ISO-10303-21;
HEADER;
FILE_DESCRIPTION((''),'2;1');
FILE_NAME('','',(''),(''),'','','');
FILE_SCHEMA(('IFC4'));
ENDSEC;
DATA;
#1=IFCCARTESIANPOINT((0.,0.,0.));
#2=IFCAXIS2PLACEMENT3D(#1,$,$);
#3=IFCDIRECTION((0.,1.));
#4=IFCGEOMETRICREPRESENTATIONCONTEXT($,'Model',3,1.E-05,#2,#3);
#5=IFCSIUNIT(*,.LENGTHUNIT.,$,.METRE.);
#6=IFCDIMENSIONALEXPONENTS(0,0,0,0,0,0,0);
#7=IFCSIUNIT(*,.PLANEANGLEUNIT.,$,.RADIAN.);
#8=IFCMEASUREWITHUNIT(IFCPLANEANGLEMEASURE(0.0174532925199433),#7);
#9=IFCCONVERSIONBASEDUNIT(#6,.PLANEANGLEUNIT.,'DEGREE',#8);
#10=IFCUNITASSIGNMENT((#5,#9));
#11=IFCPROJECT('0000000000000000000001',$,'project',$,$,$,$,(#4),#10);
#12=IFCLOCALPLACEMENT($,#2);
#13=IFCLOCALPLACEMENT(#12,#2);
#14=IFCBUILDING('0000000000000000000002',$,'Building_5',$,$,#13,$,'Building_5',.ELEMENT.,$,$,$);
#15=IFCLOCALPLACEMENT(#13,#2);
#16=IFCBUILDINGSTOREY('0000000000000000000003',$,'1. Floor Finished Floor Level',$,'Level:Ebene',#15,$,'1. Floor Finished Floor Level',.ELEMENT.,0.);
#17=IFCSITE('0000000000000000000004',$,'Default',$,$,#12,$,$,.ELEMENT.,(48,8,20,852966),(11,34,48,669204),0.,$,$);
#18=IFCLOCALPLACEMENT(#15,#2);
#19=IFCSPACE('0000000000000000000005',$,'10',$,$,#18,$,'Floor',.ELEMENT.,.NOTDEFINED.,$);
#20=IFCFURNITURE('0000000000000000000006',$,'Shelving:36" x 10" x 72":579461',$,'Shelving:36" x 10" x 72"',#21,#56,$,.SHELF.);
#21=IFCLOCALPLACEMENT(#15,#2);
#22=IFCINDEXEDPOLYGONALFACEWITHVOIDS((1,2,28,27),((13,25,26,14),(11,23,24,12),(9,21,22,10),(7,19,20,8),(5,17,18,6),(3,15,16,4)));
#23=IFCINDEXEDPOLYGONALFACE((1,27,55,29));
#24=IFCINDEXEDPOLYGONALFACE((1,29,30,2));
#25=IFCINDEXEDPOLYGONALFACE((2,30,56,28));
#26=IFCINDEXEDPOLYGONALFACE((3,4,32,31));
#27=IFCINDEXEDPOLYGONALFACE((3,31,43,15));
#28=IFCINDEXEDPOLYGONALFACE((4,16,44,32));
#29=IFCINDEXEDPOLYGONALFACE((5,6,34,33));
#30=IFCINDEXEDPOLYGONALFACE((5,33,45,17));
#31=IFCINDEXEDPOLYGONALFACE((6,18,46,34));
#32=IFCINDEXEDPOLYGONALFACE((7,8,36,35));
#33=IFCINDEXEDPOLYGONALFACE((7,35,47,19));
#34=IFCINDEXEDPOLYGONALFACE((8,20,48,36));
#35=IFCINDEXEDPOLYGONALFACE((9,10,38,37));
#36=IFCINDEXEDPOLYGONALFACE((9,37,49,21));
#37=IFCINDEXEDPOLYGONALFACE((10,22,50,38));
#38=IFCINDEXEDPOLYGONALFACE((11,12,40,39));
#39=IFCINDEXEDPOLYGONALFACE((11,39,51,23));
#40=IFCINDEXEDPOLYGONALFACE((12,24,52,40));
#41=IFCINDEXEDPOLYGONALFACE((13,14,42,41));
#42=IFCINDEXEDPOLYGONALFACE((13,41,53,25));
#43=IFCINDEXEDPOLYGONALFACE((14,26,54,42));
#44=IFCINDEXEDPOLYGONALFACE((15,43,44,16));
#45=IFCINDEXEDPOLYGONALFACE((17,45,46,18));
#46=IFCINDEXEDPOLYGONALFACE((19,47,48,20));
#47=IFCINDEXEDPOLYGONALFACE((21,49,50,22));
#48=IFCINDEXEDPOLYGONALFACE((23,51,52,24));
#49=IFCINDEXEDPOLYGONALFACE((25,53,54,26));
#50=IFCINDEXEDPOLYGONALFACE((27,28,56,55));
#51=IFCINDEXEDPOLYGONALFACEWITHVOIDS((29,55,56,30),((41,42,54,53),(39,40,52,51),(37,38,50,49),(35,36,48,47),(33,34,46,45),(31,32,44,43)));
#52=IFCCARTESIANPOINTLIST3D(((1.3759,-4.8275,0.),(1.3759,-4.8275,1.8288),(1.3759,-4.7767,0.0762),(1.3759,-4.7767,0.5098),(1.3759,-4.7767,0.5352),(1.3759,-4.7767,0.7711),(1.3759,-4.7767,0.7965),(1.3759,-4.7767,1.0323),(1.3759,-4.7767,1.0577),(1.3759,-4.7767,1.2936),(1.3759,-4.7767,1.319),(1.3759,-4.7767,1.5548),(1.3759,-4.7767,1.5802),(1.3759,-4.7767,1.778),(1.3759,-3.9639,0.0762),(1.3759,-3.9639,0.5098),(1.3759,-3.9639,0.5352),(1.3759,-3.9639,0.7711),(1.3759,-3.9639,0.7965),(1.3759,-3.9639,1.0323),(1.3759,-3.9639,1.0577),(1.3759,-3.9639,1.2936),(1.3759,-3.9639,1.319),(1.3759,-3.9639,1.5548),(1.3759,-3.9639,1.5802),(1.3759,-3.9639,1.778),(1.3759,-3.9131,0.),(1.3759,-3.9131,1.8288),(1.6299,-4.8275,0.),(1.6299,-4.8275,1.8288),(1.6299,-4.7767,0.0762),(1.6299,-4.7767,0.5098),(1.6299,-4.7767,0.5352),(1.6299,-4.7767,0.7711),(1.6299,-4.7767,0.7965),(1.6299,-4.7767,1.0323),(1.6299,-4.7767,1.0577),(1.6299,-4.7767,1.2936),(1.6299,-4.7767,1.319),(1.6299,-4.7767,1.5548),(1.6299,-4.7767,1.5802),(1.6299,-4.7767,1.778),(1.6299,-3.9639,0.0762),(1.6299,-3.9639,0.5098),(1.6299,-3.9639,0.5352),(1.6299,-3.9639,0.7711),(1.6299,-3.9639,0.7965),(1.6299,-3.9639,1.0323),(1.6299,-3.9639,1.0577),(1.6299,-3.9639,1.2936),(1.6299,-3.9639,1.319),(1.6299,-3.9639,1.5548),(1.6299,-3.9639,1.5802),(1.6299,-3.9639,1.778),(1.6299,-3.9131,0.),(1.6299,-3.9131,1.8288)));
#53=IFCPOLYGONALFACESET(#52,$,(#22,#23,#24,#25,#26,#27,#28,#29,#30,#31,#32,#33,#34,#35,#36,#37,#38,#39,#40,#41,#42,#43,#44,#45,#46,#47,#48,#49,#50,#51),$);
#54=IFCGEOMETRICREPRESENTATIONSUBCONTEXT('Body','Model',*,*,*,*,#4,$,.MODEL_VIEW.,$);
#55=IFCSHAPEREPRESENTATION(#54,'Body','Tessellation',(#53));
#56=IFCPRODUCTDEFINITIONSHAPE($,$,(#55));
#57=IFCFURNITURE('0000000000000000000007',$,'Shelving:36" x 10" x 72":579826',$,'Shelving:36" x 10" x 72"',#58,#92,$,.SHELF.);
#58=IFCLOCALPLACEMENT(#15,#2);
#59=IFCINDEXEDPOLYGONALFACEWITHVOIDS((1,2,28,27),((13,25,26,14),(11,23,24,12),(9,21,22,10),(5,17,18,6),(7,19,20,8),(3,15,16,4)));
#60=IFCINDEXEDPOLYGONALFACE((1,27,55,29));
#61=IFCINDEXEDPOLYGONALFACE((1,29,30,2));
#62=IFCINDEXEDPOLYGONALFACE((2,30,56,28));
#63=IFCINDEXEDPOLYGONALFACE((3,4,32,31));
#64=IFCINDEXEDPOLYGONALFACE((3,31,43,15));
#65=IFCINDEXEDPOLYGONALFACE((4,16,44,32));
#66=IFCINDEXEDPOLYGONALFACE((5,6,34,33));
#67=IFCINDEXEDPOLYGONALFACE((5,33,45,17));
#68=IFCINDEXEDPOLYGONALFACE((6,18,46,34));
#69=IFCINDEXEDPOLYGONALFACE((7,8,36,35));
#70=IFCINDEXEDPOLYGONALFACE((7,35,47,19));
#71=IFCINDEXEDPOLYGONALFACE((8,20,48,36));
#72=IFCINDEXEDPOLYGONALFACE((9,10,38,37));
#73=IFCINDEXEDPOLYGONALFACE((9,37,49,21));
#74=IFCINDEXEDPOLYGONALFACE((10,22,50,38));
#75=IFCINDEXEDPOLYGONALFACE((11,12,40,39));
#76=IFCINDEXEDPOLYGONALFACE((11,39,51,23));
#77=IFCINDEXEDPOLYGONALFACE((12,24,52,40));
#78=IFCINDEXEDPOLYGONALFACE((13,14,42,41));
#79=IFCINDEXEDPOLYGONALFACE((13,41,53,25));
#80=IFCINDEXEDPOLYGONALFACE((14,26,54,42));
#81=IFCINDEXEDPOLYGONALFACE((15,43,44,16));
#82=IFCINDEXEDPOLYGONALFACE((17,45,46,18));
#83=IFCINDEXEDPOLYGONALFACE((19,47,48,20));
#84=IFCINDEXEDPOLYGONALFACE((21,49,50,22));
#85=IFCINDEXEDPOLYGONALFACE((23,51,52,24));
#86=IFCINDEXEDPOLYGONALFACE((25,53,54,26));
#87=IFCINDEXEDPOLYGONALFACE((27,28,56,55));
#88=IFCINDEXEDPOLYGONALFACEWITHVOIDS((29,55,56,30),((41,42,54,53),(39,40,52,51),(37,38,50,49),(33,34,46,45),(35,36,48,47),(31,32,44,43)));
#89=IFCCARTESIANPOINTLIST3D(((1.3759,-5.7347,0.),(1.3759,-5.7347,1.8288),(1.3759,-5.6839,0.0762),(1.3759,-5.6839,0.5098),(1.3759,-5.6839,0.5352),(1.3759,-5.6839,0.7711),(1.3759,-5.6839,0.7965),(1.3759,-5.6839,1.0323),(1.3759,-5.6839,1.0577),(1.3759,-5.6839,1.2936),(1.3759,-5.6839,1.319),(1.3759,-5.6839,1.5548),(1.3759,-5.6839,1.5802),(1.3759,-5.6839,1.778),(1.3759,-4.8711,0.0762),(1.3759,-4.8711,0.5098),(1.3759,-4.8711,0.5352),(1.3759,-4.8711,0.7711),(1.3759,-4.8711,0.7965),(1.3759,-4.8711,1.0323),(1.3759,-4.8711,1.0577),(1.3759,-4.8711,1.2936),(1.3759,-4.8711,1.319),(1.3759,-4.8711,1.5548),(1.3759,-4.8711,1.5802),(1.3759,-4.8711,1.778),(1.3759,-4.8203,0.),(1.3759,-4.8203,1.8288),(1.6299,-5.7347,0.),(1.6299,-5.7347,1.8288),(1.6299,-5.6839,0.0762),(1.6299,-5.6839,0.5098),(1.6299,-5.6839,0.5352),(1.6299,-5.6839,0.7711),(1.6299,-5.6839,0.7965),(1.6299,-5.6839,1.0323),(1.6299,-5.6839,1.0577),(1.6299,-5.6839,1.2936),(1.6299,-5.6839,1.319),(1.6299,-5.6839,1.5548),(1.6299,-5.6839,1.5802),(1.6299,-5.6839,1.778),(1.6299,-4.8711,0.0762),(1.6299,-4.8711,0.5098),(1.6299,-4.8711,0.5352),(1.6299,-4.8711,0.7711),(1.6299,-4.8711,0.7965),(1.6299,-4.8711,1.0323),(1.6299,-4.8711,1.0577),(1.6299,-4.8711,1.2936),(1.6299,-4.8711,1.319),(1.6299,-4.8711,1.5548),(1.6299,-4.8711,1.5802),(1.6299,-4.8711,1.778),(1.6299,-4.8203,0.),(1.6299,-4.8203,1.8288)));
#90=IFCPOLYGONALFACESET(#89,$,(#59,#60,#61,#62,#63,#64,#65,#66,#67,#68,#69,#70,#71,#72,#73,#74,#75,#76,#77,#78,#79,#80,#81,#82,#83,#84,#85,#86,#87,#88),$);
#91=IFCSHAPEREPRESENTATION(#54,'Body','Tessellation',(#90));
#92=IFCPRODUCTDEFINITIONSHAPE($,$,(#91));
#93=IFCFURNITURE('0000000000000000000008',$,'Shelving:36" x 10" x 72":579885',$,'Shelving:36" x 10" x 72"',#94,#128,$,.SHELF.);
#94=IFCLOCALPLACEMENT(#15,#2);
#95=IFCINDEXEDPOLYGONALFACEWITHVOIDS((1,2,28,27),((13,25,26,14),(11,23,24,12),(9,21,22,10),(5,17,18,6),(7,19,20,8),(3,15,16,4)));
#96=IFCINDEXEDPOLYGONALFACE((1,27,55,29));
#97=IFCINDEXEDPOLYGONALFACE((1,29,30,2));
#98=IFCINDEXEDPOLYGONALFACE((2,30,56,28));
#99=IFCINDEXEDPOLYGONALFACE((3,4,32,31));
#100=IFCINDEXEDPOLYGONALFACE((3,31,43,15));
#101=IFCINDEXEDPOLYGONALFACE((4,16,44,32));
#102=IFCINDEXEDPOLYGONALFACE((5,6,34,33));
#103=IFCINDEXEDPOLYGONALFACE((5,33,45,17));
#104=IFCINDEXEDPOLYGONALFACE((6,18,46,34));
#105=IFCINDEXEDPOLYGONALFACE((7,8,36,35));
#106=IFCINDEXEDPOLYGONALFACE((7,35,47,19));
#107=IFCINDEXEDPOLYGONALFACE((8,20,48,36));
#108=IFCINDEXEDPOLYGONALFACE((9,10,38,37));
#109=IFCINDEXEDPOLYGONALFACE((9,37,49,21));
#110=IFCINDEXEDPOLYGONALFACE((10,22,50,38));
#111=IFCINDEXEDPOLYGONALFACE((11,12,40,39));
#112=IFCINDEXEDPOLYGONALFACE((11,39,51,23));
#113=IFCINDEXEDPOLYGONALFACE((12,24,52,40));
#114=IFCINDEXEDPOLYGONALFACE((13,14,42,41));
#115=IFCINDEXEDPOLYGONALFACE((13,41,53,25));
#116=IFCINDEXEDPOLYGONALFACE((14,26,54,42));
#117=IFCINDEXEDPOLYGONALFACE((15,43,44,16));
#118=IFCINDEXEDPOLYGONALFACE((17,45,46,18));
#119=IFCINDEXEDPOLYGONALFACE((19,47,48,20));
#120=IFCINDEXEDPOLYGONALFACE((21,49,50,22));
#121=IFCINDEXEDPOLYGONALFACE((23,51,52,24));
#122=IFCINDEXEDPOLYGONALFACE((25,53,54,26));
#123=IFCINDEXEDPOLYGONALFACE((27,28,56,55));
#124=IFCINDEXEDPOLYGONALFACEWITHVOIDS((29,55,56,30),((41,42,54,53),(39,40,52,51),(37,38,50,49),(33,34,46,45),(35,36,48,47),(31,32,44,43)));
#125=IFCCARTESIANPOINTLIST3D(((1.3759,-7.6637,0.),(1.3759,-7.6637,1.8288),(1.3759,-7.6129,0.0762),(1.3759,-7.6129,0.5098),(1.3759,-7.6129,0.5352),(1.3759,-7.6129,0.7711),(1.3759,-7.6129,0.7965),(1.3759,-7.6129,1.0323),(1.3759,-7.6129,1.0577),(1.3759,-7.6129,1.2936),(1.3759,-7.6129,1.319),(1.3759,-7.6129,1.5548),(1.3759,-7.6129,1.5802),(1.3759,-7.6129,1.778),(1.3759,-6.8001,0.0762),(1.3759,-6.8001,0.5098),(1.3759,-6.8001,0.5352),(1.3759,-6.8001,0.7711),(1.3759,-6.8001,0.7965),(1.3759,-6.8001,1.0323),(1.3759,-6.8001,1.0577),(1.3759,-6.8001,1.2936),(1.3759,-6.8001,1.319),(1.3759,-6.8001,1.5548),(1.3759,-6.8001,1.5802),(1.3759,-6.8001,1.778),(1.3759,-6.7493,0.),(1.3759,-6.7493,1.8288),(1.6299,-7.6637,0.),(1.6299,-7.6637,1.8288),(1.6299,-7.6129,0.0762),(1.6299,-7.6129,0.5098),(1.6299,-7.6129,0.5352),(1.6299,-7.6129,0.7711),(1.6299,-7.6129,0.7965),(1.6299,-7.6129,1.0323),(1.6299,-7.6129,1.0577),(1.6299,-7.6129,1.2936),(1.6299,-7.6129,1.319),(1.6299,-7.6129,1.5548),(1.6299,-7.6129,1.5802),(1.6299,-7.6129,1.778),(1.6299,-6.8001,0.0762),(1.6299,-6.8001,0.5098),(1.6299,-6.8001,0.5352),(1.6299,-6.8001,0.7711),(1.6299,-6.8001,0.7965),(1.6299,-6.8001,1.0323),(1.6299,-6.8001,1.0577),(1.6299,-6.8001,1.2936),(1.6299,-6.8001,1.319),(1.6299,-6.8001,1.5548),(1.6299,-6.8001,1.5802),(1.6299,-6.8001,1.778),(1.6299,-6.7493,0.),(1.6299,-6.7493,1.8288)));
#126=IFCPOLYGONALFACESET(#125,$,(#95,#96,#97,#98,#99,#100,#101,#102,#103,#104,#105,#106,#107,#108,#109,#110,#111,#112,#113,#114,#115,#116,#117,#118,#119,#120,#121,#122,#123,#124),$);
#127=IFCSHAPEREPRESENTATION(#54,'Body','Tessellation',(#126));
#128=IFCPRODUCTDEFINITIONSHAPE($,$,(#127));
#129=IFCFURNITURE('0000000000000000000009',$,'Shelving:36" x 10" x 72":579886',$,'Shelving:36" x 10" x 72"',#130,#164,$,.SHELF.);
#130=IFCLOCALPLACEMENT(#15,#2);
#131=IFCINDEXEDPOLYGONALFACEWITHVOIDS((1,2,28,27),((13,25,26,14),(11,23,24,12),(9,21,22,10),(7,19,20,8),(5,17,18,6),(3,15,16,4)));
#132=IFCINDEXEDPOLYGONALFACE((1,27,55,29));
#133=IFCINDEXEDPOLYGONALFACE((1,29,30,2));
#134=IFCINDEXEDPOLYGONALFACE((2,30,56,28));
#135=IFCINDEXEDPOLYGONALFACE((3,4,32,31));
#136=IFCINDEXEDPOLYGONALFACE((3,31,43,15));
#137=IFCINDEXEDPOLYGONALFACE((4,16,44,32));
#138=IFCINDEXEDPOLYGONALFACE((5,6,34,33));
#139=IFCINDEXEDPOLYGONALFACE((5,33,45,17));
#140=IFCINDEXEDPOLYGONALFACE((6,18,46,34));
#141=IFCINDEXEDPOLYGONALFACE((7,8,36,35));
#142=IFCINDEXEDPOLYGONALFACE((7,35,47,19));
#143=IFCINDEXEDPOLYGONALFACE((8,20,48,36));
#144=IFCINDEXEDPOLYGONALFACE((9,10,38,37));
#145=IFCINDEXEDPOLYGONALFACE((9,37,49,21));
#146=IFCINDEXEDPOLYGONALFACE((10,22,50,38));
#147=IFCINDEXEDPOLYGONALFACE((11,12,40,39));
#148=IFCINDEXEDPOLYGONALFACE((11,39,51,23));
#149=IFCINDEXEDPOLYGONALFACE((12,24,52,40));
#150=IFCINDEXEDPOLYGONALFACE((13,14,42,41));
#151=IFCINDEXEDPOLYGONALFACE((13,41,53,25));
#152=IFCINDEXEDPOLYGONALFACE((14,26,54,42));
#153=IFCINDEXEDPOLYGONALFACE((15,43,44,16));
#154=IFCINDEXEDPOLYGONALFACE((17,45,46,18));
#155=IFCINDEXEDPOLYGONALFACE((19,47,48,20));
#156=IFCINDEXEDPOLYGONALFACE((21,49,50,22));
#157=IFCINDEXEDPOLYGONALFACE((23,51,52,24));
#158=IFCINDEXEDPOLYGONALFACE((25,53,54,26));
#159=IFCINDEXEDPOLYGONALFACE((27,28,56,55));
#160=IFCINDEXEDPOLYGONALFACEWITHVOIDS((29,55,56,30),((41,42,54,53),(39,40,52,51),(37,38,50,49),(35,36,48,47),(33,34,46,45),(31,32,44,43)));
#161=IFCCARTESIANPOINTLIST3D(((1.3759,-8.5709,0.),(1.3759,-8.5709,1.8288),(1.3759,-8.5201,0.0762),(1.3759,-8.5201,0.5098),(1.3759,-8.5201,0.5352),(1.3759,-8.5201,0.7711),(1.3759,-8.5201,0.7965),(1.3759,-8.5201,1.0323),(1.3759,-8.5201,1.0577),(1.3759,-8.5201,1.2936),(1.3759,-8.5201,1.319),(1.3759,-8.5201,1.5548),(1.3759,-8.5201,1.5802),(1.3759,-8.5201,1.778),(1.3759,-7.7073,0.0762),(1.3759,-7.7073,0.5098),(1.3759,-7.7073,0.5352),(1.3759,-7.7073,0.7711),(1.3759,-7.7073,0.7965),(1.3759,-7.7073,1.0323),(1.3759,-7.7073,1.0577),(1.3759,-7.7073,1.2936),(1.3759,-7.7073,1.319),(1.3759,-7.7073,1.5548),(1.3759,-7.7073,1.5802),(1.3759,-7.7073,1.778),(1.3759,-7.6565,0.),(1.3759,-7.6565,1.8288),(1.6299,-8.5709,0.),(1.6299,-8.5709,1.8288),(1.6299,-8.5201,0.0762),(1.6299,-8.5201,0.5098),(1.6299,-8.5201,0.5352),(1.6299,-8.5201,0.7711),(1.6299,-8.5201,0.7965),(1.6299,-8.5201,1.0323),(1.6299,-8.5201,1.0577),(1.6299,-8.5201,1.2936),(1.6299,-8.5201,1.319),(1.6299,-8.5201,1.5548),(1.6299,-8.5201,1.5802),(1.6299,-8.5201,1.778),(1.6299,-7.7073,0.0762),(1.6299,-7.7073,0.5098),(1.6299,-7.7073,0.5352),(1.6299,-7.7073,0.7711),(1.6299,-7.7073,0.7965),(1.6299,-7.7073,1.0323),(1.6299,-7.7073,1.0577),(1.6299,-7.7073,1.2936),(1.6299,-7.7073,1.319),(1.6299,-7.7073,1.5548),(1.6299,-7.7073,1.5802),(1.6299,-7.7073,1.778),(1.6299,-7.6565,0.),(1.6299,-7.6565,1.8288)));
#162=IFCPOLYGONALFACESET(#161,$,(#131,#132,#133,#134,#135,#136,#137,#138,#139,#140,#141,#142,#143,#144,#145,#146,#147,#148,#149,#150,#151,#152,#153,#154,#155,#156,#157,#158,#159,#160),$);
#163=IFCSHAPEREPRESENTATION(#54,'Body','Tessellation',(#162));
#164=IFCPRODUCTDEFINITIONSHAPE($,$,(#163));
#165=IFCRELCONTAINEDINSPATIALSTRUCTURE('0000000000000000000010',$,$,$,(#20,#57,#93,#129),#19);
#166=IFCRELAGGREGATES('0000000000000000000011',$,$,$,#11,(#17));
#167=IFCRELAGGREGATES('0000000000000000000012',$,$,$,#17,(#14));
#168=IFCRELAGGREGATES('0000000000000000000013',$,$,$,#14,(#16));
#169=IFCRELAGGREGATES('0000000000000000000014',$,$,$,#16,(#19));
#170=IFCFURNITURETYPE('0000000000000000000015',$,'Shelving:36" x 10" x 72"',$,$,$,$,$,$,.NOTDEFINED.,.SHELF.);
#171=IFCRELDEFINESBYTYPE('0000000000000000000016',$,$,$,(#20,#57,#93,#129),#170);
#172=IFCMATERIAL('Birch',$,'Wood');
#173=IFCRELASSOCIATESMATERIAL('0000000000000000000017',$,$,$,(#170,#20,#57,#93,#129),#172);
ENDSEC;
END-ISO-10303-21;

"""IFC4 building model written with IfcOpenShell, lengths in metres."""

from ifc_helpers import new_model, entity, si_unit, converted_unit, direction, frame, origin, place, context, subcontext, project, spatial, indexed_curve, outline, extrude, source, transform, mapped, material, type_object, type_shapes, element, save


model = new_model("IFC4")

# Units and contexts
model_context = context("Model", 3, precision=1e-05, world=origin(), true_north=direction((0.0, 1.0)))
body_context = subcontext(model_context, "Body", "Model", "MODEL_VIEW")
ifc_project = project(units=[si_unit("LENGTHUNIT", "METRE"), converted_unit("PLANEANGLEUNIT", "DEGREE", entity("IfcPlaneAngleMeasure", 0.0174532925199433), si_unit("PLANEANGLEUNIT", "RADIAN"), dimensions=[0, 0, 0, 0, 0, 0, 0])], contexts=[model_context])

# Site, building, storey
site_placement = place(None, origin())
site = spatial("IfcSite", under=ifc_project, at=site_placement, Name="Default", CompositionType="ELEMENT", RefLatitude=(48, 8, 20, 852966), RefLongitude=(11, 34, 48, 669204), RefElevation=0.0)
building_placement = place(site_placement, origin())
building = spatial("IfcBuilding", under=site, at=building_placement, Name="Building_5", LongName="Building_5", CompositionType="ELEMENT")
storey_placement = place(building_placement, origin())
storey = spatial("IfcBuildingStorey", under=building, at=storey_placement, Name="1. Floor Finished Floor Level", ObjectType="Level:Ebene", LongName="1. Floor Finished Floor Level", CompositionType="ELEMENT", Elevation=0.0)

# Shared definitions
space_placement = place(storey_placement, origin())
space = spatial("IfcSpace", under=storey, at=space_placement, Name="10", LongName="Floor", CompositionType="ELEMENT", PredefinedType="NOTDEFINED")

# Furniture
ifc_material_1 = material(Name="Birch", Category="Wood")
furniture_type = type_object("IfcFurnitureType", Name="Shelving:36\" x 10\" x 72\"", AssemblyPlace="NOTDEFINED", PredefinedType="SHELF", material=ifc_material_1)
shared_shape_1 = source(origin(), body_context, "Body", "SweptSolid", [
    extrude(outline(indexed_curve([(-0.4572, -0.9144), (0.4572, -0.9144), (0.4572, 0.9144), (-0.4572, 0.9144), (-0.4572, -0.9144)], self_intersect=False), holes=[indexed_curve([(-0.4064, 0.8636), (0.4064, 0.8636), (0.4064, 0.6658), (-0.4064, 0.6658), (-0.4064, 0.8636)], self_intersect=False), indexed_curve([(-0.4064, -0.8382), (-0.4064, -0.4046), (0.4064, -0.4046), (0.4064, -0.8382), (-0.4064, -0.8382)], self_intersect=False), indexed_curve([(0.4064, 0.1433), (-0.4064, 0.1433), (-0.4064, 0.3792), (0.4064, 0.3792), (0.4064, 0.1433)], self_intersect=False), indexed_curve([(-0.4064, 0.6404), (0.4064, 0.6404), (0.4064, 0.4046), (-0.4064, 0.4046), (-0.4064, 0.6404)], self_intersect=False), indexed_curve([(-0.4064, 0.1179), (0.4064, 0.1179), (0.4064, -0.1179), (-0.4064, -0.1179), (-0.4064, 0.1179)], self_intersect=False), indexed_curve([(-0.4064, -0.1433), (0.4064, -0.1433), (0.4064, -0.3792), (-0.4064, -0.3792), (-0.4064, -0.1433)], self_intersect=False)]), frame((0.0, -0.4318, 0.9144), z_axis=(0.0, 1.0, 0.0), x_axis=(-1.0, 0.0, 0.0)), (0.0, 0.0, 1.0), 0.254),
])
type_shapes(furniture_type, [shared_shape_1])
for number, where, z_axis, x_axis, name in (
    (1, (1.1981, -4.3703, 0.0), (0.0, 0.0, 1.0), (0.0, 1.0, 0.0), "Shelving:36\" x 10\" x 72\":579461"),
    (2, (1.1981, -5.2775, 0.0), (0.0, 0.0, 1.0), (0.0, 1.0, 0.0), "Shelving:36\" x 10\" x 72\":579826"),
    (3, (1.1981, -7.2065, 0.0), (0.0, 0.0, 1.0), (0.0, 1.0, 0.0), "Shelving:36\" x 10\" x 72\":579885"),
    (4, (1.1981, -8.1137, 0.0), (0.0, 0.0, 1.0), (0.0, 1.0, 0.0), "Shelving:36\" x 10\" x 72\":579886"),
):
    element("IfcFurniture", number, at=place(space_placement, frame(where, z_axis=z_axis, x_axis=x_axis)), inside=space, type_object=furniture_type, material=ifc_material_1, Name=name, ObjectType="Shelving:36\" x 10\" x 72\"", PredefinedType="SHELF", context=body_context, shape_type="MappedRepresentation", body=[
        mapped(shared_shape_1, transform((0.0, 0.0, 0.0), scale=1.0)),
    ])

save(model, "model.ifc")
